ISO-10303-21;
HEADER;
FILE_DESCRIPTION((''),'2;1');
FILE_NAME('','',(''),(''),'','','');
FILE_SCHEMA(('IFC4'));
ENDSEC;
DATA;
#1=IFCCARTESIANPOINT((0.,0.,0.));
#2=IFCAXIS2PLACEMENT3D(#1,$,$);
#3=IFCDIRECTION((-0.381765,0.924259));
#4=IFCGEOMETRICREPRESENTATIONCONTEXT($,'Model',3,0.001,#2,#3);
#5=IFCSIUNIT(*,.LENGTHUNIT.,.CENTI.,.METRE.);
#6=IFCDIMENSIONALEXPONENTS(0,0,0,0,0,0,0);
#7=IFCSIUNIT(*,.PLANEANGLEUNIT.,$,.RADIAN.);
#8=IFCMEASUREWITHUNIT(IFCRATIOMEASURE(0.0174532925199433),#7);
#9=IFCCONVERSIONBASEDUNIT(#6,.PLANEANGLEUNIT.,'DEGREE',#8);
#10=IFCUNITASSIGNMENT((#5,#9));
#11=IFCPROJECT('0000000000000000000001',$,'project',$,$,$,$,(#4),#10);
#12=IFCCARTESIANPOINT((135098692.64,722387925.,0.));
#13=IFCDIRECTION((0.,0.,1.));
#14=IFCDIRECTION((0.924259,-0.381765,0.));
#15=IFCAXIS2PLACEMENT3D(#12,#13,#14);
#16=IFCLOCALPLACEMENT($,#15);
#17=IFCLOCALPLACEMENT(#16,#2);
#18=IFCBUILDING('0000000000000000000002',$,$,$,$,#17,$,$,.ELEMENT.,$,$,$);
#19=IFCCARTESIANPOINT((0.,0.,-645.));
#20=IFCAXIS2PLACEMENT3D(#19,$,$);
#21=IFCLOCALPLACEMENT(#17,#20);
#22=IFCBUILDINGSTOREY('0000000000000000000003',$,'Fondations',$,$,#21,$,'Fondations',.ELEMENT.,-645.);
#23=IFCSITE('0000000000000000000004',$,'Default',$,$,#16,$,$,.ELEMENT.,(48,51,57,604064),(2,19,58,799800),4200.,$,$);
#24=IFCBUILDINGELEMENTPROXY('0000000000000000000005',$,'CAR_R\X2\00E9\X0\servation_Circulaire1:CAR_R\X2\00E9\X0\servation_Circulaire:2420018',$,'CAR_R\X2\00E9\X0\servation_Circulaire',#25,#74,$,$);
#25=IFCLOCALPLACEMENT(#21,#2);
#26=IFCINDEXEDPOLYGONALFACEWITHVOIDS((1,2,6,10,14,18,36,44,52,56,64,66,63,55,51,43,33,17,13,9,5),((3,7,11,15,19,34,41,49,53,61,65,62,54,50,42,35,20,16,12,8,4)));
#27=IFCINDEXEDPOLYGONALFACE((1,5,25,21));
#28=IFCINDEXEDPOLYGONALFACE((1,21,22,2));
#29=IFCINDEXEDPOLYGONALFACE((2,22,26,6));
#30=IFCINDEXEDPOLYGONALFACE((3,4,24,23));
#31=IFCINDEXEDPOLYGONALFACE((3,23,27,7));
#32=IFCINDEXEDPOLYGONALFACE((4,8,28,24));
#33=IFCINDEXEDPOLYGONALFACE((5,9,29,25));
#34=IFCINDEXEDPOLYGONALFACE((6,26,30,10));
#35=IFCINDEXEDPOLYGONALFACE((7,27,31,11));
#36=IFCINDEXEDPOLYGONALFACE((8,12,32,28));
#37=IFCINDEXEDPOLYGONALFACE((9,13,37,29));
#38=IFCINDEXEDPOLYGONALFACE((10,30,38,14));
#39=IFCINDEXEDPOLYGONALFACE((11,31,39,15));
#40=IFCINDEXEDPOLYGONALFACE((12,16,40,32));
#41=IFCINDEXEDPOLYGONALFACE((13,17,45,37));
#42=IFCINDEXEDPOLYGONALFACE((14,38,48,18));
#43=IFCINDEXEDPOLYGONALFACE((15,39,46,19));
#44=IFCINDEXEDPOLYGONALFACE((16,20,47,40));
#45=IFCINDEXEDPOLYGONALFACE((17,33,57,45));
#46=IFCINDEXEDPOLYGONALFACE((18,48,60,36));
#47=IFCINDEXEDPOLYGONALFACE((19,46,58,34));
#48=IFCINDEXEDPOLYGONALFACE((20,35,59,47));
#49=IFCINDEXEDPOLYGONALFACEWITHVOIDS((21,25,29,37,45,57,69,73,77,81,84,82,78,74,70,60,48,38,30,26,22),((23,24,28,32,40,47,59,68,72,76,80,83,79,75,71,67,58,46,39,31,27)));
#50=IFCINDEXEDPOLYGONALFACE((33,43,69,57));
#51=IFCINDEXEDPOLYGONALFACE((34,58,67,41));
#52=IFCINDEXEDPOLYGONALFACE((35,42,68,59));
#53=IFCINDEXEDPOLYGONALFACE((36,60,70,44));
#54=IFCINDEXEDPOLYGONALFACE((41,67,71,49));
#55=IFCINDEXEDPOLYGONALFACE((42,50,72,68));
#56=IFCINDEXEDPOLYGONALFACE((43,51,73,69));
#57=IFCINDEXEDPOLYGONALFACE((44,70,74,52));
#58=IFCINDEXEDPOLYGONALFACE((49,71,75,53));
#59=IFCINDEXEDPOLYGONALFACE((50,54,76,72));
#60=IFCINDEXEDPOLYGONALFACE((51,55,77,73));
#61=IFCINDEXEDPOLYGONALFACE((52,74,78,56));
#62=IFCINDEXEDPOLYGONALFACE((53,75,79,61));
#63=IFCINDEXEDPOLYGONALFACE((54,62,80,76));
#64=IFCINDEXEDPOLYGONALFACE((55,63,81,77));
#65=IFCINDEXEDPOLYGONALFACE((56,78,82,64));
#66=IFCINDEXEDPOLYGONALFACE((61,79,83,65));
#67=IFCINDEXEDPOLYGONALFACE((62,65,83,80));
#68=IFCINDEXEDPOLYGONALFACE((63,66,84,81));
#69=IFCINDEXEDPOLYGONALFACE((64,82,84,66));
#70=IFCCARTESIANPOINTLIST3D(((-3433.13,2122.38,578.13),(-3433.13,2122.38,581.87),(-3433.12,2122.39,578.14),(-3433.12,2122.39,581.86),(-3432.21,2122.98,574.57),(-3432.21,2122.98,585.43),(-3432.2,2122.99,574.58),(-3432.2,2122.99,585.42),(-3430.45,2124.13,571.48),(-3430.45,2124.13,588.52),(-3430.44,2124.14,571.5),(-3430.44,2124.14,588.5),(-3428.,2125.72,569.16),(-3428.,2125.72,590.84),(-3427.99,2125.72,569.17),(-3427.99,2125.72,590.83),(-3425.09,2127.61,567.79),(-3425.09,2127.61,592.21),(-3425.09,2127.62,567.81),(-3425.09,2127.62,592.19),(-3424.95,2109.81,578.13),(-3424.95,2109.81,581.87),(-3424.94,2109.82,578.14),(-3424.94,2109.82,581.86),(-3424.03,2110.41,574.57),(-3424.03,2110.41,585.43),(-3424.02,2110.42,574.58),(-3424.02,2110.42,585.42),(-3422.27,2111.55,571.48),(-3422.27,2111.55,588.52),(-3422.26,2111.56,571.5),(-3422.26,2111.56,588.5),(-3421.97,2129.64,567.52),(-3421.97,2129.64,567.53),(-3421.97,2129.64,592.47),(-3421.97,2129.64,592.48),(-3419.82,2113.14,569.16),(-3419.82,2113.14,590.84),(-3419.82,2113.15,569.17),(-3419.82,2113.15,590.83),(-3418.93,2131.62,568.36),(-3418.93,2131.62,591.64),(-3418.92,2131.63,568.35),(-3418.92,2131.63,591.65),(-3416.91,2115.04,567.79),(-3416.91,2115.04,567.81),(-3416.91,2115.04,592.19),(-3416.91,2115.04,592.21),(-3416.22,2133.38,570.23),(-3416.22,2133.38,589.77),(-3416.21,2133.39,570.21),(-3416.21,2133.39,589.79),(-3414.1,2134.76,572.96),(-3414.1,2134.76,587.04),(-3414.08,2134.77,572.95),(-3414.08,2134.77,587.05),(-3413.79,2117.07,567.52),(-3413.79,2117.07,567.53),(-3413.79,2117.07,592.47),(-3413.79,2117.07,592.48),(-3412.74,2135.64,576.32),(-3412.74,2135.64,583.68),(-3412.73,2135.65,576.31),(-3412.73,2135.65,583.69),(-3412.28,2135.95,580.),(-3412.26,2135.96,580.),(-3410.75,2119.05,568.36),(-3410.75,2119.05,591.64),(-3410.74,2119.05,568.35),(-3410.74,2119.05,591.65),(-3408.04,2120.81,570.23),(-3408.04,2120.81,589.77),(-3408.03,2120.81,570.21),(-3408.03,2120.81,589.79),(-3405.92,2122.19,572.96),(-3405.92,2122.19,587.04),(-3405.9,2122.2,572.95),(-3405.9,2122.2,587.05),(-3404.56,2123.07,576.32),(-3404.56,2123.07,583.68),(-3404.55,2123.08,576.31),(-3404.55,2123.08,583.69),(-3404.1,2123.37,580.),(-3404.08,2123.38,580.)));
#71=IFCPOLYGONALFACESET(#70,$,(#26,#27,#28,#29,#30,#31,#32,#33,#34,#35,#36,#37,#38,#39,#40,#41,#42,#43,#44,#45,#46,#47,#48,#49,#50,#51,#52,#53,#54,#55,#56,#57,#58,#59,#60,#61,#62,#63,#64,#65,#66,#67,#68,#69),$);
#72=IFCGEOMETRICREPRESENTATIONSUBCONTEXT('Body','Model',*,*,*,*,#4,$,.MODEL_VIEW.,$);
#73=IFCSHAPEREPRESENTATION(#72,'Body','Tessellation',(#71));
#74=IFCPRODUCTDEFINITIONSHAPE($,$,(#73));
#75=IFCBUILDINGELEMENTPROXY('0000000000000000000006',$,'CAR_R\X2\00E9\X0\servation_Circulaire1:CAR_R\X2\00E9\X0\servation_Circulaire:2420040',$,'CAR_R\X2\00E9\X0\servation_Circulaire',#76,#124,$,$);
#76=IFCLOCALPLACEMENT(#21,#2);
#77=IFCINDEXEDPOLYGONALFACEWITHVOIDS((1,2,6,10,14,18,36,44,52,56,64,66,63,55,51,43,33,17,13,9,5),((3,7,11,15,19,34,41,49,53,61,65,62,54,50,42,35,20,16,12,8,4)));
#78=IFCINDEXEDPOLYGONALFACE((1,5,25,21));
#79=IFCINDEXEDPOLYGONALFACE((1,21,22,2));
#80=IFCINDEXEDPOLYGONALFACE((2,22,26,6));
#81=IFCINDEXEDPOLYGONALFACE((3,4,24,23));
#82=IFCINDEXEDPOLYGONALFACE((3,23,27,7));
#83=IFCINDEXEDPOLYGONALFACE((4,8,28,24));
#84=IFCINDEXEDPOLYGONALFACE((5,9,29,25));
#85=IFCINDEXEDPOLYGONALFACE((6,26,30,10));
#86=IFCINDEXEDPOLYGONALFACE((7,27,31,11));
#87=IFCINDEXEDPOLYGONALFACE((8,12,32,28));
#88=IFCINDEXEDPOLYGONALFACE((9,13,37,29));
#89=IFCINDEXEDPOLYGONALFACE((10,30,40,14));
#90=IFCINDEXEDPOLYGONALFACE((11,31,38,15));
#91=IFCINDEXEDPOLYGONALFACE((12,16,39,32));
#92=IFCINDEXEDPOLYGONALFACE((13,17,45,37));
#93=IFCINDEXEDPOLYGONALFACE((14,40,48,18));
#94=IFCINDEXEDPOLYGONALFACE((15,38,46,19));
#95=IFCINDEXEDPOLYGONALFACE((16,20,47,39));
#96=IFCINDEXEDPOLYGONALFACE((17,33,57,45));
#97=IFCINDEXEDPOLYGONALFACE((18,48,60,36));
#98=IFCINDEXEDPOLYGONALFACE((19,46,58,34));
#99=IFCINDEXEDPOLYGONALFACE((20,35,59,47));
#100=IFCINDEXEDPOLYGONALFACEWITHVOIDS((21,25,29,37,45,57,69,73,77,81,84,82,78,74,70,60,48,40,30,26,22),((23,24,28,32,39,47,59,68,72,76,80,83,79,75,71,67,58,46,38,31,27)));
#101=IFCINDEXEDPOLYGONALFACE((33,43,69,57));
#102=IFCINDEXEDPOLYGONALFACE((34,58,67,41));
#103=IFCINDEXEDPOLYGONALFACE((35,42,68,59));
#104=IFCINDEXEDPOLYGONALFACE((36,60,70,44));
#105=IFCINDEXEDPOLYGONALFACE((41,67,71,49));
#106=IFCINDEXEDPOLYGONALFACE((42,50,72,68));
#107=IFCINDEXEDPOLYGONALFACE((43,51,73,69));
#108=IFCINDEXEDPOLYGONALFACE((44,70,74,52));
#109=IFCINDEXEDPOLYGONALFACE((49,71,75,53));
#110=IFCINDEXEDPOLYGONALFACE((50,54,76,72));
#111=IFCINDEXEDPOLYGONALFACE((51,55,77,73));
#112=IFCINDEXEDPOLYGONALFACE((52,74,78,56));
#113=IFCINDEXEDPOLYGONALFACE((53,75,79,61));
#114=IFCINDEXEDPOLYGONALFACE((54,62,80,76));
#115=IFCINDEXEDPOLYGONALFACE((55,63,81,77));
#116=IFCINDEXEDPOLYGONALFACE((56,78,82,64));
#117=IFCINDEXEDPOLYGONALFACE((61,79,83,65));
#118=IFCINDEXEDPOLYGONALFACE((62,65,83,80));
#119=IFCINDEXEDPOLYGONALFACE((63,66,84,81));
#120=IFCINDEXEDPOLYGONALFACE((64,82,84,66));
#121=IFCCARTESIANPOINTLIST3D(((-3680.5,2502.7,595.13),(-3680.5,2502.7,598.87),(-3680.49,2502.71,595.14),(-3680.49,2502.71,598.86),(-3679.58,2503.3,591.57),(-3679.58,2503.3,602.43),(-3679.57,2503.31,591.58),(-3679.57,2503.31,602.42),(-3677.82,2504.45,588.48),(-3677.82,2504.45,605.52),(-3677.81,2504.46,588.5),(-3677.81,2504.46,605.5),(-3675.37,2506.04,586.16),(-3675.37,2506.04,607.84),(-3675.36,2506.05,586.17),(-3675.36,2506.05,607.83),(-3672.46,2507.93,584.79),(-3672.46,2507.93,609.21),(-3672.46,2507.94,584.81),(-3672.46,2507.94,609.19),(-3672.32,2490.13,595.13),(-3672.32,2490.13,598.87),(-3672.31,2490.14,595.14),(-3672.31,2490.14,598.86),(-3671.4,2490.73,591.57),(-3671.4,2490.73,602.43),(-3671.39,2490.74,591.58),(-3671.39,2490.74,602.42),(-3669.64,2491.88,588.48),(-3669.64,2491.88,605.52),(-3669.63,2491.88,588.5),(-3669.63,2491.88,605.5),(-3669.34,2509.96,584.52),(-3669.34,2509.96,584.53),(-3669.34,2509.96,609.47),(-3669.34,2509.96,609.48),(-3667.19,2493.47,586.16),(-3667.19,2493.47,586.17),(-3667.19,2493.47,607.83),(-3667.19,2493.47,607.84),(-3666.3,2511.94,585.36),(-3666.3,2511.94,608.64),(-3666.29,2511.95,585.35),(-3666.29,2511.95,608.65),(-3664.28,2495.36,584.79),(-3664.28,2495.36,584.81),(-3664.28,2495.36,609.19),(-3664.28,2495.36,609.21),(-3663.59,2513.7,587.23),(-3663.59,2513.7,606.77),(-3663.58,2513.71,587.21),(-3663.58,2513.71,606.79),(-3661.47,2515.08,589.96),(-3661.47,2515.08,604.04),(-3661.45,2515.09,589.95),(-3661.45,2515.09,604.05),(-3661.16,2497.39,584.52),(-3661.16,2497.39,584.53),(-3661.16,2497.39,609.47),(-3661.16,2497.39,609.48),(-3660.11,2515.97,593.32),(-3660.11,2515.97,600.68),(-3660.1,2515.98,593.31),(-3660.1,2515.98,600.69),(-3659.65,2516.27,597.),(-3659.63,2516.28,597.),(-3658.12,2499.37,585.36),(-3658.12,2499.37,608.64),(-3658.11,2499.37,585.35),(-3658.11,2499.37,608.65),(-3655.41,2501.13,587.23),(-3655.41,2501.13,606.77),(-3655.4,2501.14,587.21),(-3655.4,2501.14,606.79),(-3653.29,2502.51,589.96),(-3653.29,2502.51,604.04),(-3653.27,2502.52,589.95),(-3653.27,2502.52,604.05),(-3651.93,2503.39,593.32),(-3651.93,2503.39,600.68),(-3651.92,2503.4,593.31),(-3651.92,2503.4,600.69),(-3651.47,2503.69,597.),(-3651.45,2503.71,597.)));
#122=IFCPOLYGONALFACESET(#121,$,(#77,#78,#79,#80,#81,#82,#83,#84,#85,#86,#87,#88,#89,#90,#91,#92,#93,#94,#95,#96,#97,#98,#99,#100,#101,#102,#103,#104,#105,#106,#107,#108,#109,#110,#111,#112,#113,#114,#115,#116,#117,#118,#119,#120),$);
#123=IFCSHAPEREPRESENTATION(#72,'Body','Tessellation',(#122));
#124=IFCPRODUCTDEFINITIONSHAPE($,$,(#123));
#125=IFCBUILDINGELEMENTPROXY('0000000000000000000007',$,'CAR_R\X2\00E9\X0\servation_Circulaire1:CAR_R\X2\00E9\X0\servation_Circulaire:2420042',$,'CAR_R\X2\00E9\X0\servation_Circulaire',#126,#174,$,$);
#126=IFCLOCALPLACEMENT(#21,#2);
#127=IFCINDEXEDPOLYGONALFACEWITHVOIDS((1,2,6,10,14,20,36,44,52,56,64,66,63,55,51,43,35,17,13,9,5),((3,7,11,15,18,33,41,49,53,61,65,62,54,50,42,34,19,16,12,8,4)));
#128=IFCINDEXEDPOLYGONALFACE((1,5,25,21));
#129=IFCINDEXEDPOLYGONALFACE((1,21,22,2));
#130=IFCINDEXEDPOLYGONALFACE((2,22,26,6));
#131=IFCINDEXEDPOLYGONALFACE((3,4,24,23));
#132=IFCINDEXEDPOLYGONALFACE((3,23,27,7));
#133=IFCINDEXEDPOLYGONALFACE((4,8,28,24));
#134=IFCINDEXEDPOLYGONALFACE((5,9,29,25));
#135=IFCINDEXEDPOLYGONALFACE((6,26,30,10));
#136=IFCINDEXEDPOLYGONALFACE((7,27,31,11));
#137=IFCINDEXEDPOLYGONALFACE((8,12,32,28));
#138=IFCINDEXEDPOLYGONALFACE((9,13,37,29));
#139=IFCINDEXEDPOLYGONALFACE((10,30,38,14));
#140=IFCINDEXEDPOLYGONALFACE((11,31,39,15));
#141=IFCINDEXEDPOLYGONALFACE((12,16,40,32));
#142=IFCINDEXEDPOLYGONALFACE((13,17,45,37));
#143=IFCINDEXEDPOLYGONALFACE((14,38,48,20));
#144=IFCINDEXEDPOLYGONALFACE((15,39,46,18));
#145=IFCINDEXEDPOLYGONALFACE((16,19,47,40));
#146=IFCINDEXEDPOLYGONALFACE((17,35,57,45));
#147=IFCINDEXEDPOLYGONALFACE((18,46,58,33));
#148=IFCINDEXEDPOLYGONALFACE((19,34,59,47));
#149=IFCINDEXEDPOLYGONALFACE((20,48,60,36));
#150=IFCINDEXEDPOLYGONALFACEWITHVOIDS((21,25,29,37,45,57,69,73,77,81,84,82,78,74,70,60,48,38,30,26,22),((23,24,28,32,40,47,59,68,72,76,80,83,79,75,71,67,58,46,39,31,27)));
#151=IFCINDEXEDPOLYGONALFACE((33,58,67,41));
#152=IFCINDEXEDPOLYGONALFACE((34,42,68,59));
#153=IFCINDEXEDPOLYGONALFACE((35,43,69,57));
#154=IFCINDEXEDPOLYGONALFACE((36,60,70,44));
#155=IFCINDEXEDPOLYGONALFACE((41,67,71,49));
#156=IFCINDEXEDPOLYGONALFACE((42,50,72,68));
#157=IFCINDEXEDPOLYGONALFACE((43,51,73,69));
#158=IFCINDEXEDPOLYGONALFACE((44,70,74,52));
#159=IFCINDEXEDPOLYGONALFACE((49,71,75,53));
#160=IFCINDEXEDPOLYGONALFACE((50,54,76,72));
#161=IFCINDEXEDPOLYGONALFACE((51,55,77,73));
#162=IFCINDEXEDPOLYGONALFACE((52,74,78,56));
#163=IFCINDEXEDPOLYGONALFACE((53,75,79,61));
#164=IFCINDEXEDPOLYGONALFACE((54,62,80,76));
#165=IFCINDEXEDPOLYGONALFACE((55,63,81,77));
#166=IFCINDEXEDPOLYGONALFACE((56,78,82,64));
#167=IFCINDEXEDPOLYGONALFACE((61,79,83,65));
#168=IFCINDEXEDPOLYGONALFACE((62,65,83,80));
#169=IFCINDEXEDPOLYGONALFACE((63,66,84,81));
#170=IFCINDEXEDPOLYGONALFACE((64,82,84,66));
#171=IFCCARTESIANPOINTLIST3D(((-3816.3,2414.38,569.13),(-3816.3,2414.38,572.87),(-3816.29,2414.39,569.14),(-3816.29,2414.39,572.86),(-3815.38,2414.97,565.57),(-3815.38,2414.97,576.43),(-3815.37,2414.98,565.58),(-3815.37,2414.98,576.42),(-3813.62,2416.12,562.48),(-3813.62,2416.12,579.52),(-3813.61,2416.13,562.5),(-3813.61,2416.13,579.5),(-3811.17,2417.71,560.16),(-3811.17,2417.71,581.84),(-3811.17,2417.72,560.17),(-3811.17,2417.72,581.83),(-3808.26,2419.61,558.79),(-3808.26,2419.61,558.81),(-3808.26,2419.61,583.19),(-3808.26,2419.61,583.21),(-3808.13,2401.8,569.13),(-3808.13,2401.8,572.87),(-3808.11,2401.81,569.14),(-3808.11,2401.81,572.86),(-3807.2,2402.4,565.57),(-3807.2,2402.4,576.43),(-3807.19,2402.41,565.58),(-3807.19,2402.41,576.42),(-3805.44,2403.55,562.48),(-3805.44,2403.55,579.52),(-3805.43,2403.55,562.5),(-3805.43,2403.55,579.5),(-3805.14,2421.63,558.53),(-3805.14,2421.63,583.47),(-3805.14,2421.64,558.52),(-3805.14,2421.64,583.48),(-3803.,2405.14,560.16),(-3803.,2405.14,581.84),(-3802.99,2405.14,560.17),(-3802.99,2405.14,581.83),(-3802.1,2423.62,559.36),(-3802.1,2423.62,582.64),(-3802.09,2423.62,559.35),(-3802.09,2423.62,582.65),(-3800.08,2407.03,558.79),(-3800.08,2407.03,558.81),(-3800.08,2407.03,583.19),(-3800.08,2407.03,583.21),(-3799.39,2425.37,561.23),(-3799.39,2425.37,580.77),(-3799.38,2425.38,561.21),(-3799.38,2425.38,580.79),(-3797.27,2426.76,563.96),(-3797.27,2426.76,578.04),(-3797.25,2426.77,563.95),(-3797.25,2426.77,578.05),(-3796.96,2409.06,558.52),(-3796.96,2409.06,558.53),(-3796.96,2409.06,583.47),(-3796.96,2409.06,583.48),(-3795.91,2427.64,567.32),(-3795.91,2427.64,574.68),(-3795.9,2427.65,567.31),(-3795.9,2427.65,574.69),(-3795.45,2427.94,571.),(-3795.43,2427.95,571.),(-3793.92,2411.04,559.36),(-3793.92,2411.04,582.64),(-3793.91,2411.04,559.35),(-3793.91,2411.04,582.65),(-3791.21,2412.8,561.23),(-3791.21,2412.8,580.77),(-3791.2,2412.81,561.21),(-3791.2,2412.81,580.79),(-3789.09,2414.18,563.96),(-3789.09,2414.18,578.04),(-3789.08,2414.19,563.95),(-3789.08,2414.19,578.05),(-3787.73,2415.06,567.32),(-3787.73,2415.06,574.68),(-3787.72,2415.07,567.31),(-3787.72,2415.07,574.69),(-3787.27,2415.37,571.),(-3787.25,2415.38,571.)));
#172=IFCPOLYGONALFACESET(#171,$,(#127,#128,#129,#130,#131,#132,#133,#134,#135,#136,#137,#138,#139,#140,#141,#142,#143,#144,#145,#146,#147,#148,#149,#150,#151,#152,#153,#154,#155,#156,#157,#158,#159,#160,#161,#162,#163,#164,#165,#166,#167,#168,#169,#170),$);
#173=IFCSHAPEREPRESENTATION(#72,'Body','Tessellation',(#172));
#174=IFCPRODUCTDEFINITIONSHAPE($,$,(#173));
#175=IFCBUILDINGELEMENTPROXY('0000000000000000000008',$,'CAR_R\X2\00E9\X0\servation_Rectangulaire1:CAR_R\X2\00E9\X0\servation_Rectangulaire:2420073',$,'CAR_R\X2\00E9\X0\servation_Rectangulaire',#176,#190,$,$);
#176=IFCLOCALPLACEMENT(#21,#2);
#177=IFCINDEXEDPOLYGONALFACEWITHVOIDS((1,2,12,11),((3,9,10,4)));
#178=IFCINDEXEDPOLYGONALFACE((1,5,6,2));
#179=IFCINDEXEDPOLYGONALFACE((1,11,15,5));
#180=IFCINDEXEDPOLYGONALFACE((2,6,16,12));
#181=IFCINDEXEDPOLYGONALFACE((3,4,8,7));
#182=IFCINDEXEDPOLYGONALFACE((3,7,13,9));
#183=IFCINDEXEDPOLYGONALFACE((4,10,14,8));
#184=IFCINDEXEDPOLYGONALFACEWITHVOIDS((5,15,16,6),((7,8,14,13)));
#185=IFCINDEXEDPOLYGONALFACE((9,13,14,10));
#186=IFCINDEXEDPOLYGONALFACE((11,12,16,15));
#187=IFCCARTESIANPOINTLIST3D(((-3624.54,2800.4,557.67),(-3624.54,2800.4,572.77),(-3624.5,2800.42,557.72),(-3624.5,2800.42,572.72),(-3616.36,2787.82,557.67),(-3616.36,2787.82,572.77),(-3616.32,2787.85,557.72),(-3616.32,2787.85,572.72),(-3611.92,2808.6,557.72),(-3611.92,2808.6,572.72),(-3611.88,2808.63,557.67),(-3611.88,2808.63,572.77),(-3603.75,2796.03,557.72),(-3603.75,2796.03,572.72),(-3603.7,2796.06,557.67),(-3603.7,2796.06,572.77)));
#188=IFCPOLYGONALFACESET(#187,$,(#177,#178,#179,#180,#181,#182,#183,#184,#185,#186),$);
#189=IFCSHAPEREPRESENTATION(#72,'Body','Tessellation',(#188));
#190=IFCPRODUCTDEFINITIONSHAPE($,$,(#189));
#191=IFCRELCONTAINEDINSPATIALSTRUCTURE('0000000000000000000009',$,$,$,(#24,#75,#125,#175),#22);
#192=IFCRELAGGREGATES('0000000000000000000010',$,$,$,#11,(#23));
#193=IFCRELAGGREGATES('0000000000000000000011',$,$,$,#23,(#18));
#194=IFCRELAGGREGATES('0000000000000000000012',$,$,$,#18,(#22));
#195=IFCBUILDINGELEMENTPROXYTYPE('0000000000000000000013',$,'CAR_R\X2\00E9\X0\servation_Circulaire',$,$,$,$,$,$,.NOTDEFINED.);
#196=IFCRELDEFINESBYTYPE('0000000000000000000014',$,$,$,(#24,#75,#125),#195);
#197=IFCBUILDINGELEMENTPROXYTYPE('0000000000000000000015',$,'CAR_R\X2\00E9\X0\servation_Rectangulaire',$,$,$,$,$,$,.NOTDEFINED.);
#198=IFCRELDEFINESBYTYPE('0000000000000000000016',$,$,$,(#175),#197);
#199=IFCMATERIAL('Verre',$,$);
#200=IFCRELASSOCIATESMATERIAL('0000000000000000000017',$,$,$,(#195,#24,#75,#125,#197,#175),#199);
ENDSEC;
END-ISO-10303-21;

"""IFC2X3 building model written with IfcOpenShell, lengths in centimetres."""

from ifc_helpers import new_model, entity, si_unit, converted_unit, direction, frame, frame_2d, origin, place, context, subcontext, project, spatial, polyline, hollow_circle, outline, extrude, source, transform, mapped, material, type_object, type_shapes, element, save


model = new_model("IFC2X3")

# Units and contexts
model_context = context("Model", 3, precision=0.001, world=origin(), true_north=direction((-0.381765, 0.924259)))
body_context = subcontext(model_context, "Body", "Model", "MODEL_VIEW")
ifc_project = project(units=[si_unit("LENGTHUNIT", "METRE", prefix="CENTI"), converted_unit("PLANEANGLEUNIT", "DEGREE", entity("IfcRatioMeasure", 0.0174532925199433), si_unit("PLANEANGLEUNIT", "RADIAN"), dimensions=[0, 0, 0, 0, 0, 0, 0])], contexts=[model_context])

# Site, building, storey
site_placement = place(None, frame((135098692.64, 722387925.0, 0.0), z_axis=(0.0, 0.0, 1.0), x_axis=(0.924259, -0.381765, 0.0)))
site = spatial("IfcSite", under=ifc_project, at=site_placement, Name="Default", CompositionType="ELEMENT", RefLatitude=(48, 51, 57, 604064), RefLongitude=(2, 19, 58, 799800), RefElevation=4200.0)
building_placement = place(site_placement, origin())
building = spatial("IfcBuilding", under=site, at=building_placement, CompositionType="ELEMENT")
storey_placement = place(building_placement, frame((0.0, 0.0, -645.0)))
storey = spatial("IfcBuildingStorey", under=building, at=storey_placement, Name="Fondations", LongName="Fondations", CompositionType="ELEMENT", Elevation=-645.0)

# Building element proxies
ifc_material_1 = material(Name="Verre")
building_element_proxy_type_1 = type_object("IfcBuildingElementProxyType", Name="CAR_Réservation_Circulaire", PredefinedType="NOTDEFINED", material=ifc_material_1)
shared_shape_1 = source(origin(), body_context, "Body", "SweptSolid", [
    extrude(hollow_circle(Radius=12.52, WallThickness=0.02, at=frame_2d((0.0, 0.0), x_axis=(1.0, 0.0))), frame((0.0, 0.0, -15.0)), (0.0, 0.0, 1.0), 15.0),
])
type_shapes(building_element_proxy_type_1, [shared_shape_1])
for number, where, z_axis, x_axis, name in (
    (1, (-3414.58, 2116.56, 580.0), (0.545236, -0.838282, 0.0), (0.838282, 0.545236, 0.0), "CAR_Réservation_Circulaire1:CAR_Réservation_Circulaire:2420018"),
    (2, (-3661.95, 2496.88, 597.0), (0.545236, -0.838282, 0.0), (0.838282, 0.545236, 0.0), "CAR_Réservation_Circulaire1:CAR_Réservation_Circulaire:2420040"),
    (3, (-3797.75, 2408.55, 571.0), (0.545236, -0.838282, 0.0), (0.838282, 0.545236, 0.0), "CAR_Réservation_Circulaire1:CAR_Réservation_Circulaire:2420042"),
):
    element("IfcBuildingElementProxy", number, at=place(storey_placement, frame(where, z_axis=z_axis, x_axis=x_axis)), inside=storey, type_object=building_element_proxy_type_1, material=ifc_material_1, Name=name, ObjectType="CAR_Réservation_Circulaire", context=body_context, shape_type="MappedRepresentation", body=[
        mapped(shared_shape_1, transform((0.0, 0.0, 0.0), scale=1.0)),
    ])
building_element_proxy_type_2 = type_object("IfcBuildingElementProxyType", Name="CAR_Réservation_Rectangulaire", PredefinedType="NOTDEFINED", material=ifc_material_1)
shared_shape_2 = source(origin(), body_context, "Body", "SweptSolid", [
    extrude(outline(polyline([(-7.55, -7.55), (7.55, -7.55), (7.55, 7.55), (-7.55, 7.55), (-7.55, -7.55)]), holes=[polyline([(7.5, -7.5), (-7.5, -7.5), (-7.5, 7.5), (7.5, 7.5), (7.5, -7.5)])]), frame((0.0, 0.0, -15.0), z_axis=(0.0, 0.0, 1.0), x_axis=(-1.0, 0.0, 0.0)), (0.0, 0.0, 1.0), 15.0),
])
type_shapes(building_element_proxy_type_2, [shared_shape_2])
proxy_1_placement = place(storey_placement, frame((-3618.21, 2804.51, 565.22), z_axis=(-0.545236, 0.838282, 0.0), x_axis=(-0.838282, -0.545236, 0.0)))
element("IfcBuildingElementProxy", 4, at=proxy_1_placement, inside=storey, type_object=building_element_proxy_type_2, material=ifc_material_1, Name="CAR_Réservation_Rectangulaire1:CAR_Réservation_Rectangulaire:2420073", ObjectType="CAR_Réservation_Rectangulaire", context=body_context, shape_type="MappedRepresentation", body=[
    mapped(shared_shape_2, transform((0.0, 0.0, 0.0), scale=1.0)),
])

save(model, "model.ifc")
